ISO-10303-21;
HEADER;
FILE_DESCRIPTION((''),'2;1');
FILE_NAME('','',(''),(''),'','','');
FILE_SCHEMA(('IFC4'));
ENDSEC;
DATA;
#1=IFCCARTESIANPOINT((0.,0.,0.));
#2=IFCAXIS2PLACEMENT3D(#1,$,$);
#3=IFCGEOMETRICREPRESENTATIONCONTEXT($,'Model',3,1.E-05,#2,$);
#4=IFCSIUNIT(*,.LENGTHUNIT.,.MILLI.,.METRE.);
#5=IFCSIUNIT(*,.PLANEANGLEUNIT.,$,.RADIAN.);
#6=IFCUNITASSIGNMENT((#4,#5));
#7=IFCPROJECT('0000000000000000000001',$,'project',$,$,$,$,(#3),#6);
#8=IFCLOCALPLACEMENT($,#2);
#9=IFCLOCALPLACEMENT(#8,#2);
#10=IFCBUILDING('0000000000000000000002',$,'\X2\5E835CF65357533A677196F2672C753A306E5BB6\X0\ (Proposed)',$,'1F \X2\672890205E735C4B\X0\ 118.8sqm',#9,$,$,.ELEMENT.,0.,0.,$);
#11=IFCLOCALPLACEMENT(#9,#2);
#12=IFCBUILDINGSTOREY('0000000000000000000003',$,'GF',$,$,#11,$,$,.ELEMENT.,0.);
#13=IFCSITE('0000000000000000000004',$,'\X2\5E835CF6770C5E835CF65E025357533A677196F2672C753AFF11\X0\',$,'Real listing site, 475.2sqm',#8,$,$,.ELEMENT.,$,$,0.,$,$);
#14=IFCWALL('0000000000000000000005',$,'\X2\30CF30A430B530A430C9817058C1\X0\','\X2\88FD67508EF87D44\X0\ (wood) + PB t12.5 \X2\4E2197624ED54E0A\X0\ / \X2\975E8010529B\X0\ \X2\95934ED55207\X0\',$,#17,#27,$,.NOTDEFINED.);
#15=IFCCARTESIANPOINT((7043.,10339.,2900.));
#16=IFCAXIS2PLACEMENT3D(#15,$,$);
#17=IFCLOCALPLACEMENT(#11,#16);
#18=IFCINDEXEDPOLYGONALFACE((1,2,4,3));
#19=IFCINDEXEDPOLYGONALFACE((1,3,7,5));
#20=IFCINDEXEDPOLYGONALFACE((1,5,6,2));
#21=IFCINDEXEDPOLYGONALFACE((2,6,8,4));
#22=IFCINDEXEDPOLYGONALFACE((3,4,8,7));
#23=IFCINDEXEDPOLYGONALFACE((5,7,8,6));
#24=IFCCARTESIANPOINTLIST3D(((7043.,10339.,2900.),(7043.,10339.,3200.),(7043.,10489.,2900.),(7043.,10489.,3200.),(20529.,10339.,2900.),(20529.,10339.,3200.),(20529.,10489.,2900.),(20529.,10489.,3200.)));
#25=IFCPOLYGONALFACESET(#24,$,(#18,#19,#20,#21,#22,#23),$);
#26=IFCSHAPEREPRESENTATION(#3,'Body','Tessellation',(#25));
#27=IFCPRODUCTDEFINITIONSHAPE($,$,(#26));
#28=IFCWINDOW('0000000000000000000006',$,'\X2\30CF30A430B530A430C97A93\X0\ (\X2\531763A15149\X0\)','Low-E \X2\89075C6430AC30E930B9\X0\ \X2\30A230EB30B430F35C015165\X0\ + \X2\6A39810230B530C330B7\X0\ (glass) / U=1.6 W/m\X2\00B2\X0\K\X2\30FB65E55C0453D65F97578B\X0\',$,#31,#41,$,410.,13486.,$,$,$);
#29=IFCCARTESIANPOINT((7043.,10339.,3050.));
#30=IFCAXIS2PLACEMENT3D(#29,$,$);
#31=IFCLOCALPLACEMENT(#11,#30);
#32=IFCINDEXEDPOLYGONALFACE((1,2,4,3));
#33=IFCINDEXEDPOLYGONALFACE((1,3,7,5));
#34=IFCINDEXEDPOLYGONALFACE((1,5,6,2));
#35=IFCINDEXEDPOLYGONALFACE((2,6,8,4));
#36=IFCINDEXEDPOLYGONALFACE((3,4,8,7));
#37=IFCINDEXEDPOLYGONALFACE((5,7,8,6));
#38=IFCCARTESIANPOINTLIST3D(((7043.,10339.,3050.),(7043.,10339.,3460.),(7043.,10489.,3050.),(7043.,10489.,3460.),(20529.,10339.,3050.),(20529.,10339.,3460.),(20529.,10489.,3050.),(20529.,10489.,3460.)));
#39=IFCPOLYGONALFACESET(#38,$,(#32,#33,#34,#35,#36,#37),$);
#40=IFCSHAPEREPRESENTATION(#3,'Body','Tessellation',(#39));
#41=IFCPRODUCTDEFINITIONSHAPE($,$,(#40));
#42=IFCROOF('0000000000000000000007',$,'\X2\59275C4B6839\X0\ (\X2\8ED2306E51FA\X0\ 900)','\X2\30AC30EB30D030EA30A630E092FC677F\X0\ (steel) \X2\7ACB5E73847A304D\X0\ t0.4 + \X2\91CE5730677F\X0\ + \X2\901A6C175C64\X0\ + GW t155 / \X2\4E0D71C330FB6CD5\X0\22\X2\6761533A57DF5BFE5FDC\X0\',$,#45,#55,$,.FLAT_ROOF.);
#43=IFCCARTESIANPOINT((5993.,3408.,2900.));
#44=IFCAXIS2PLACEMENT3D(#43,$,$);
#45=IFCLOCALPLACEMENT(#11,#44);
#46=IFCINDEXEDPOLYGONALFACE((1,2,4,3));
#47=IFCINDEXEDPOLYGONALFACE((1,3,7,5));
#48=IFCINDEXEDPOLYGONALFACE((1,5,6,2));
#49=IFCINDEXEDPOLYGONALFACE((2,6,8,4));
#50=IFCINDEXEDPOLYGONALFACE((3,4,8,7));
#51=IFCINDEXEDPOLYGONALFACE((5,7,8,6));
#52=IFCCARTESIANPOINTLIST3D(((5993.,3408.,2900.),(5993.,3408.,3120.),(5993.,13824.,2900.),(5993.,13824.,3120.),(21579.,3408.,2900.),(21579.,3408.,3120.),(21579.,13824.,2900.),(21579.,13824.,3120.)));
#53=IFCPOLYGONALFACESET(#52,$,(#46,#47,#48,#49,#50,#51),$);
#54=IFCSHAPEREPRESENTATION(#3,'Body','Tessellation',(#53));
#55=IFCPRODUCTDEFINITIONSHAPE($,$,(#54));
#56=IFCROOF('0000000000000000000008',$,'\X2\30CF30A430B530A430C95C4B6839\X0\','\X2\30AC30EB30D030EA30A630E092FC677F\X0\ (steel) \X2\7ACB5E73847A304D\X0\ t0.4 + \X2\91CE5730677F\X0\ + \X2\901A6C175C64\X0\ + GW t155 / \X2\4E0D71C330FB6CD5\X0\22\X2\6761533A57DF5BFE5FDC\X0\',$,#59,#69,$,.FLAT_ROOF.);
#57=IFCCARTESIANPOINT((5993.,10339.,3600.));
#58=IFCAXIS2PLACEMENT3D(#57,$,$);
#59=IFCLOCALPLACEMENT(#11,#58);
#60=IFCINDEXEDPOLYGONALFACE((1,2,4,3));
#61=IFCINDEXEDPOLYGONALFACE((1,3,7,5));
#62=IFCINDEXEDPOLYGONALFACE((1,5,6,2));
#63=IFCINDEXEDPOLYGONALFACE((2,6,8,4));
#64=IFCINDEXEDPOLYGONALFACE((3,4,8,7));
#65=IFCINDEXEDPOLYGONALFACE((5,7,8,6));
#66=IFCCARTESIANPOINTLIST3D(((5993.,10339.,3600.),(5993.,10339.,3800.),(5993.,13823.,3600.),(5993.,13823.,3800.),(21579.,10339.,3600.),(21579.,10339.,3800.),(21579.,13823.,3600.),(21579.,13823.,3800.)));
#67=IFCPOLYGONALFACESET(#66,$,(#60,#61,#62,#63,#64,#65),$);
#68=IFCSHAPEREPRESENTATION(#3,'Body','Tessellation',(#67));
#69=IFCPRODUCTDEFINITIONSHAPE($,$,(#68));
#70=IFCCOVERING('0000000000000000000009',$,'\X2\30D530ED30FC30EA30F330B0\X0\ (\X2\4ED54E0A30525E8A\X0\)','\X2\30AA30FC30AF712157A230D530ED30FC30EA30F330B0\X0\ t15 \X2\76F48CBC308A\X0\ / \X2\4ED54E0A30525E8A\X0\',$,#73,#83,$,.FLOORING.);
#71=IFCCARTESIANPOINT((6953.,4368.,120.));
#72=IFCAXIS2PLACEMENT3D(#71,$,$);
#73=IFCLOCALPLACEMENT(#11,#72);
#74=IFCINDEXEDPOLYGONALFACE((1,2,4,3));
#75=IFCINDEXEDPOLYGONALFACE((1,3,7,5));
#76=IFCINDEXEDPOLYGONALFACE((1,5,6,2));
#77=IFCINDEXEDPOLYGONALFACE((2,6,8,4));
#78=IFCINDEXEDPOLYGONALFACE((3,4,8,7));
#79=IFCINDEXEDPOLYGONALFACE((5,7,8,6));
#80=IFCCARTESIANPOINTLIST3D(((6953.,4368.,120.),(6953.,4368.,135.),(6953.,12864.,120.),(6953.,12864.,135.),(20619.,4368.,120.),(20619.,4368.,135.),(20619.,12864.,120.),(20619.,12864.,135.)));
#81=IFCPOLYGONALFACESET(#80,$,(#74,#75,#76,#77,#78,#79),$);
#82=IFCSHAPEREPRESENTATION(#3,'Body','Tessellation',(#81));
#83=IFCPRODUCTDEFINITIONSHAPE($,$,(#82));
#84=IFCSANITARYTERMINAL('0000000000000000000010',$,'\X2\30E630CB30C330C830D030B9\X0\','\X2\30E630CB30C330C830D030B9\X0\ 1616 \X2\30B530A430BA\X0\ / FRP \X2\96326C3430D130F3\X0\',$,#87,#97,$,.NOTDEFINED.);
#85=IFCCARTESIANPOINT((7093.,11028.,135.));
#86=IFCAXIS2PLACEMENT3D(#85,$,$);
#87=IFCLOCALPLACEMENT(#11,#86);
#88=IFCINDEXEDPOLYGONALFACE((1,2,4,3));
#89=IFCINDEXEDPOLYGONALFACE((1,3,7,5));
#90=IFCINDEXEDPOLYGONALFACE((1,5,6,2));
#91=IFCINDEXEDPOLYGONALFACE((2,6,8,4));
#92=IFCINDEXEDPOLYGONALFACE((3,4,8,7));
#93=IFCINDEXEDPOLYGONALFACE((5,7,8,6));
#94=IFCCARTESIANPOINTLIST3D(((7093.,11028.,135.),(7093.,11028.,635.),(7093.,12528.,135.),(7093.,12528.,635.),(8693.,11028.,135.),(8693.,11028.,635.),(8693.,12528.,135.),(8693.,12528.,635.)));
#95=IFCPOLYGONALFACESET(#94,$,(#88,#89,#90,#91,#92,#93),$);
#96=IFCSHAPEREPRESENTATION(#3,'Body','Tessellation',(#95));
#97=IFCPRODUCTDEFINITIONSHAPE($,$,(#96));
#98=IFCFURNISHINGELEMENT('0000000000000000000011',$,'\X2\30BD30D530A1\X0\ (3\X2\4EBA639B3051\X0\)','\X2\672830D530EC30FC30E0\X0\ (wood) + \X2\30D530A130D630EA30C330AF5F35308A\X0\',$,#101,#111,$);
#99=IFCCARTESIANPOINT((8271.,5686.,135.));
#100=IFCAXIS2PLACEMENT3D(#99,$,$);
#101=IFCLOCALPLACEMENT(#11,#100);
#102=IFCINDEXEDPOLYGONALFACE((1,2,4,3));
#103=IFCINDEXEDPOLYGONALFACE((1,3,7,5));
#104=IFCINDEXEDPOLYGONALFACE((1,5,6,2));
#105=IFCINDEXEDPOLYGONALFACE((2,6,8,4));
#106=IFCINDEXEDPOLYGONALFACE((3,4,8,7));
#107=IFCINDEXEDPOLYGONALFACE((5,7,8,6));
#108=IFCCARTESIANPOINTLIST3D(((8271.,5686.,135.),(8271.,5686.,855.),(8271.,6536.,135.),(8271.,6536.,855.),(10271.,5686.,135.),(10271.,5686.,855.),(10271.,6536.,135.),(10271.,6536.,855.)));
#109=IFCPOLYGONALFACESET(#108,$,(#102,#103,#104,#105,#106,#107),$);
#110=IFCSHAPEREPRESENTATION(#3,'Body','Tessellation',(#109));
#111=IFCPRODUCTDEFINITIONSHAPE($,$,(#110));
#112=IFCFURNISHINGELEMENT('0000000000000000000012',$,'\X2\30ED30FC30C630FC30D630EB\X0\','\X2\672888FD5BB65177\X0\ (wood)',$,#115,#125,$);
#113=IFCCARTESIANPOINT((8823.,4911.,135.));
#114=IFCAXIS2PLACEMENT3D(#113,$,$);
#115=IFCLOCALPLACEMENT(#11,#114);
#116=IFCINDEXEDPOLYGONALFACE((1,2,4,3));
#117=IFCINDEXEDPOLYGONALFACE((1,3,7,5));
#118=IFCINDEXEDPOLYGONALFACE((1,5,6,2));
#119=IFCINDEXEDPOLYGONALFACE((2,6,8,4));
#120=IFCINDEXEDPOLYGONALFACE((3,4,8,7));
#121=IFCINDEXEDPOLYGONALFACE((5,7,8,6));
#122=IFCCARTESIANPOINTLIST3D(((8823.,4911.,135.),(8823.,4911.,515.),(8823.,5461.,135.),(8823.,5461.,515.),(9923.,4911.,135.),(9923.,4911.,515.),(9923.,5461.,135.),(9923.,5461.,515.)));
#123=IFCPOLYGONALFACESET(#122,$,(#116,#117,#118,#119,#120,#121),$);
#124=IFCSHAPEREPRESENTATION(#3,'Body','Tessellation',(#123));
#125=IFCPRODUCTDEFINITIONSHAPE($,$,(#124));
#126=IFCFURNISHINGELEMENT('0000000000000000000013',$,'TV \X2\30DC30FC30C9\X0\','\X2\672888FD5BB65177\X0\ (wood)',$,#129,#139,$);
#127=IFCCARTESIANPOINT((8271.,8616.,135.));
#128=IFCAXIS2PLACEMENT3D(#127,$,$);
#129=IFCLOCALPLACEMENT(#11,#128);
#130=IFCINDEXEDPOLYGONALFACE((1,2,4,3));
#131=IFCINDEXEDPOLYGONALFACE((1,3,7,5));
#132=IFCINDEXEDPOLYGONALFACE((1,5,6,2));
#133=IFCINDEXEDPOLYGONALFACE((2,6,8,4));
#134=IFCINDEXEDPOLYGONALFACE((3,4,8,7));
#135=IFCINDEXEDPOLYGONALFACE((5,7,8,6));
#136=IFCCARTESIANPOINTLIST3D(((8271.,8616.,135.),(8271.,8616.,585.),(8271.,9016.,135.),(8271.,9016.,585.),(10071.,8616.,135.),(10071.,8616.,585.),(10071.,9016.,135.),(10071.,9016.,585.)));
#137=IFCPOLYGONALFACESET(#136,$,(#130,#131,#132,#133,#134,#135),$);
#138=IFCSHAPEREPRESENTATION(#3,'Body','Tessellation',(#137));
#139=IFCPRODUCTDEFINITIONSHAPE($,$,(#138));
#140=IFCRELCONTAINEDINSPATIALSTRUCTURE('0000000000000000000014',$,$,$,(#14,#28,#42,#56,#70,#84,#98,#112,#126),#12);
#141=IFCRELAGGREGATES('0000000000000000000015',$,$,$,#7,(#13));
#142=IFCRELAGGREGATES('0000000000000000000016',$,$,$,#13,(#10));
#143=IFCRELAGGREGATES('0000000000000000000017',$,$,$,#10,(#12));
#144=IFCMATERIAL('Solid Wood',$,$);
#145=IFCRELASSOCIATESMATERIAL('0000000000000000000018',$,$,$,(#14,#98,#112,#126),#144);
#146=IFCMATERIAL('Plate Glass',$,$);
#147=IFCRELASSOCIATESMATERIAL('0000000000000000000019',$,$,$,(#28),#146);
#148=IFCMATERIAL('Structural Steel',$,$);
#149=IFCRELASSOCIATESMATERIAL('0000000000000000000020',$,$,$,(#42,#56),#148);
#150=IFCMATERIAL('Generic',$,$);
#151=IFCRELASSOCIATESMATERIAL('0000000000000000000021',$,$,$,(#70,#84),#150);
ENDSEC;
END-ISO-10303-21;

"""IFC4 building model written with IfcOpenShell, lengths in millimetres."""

from ifc_helpers import new_model, si_unit, frame, frame_2d, origin, place, context, project, spatial, rectangle, extrude, material, element, fill, save


model = new_model("IFC4")

# Units and contexts
model_context = context("Model", 3, precision=1e-05, world=origin())
ifc_project = project(units=[si_unit("LENGTHUNIT", "METRE", prefix="MILLI"), si_unit("PLANEANGLEUNIT", "RADIAN")], contexts=[model_context])

# Site, building, storey
site_placement = place(None, origin())
site = spatial("IfcSite", under=ifc_project, at=site_placement, Name="広島県広島市南区東雲本町１", ObjectType="Real listing site, 475.2sqm", CompositionType="ELEMENT", RefElevation=0.0)
building_placement = place(site_placement, origin())
building = spatial("IfcBuilding", under=site, at=building_placement, Name="広島南区東雲本町の家 (Proposed)", ObjectType="1F 木造平屋 118.8sqm", CompositionType="ELEMENT", ElevationOfRefHeight=0.0, ElevationOfTerrain=0.0)
storey_placement = place(building_placement, origin())
storey = spatial("IfcBuildingStorey", under=building, at=storey_placement, Name="GF", CompositionType="ELEMENT", Elevation=0.0)

# Shared definitions
ifc_material_1 = material(Name="Solid Wood")

# Shared definitions
ifc_material_2 = material(Name="Plate Glass")

# Wall, opening, window
wall_1_placement = place(storey_placement, frame((7043.0, 10339.0, 2900.0)))
wall_1 = element("IfcWall", 1, at=wall_1_placement, inside=storey, material=ifc_material_1, Name="ハイサイド腰壁", Description="製材軸組 (wood) + PB t12.5 両面仕上 / 非耐力 間仕切", PredefinedType="NOTDEFINED", context=model_context, shape_type="SweptSolid", body=[
    extrude(rectangle(XDim=13486.0, YDim=150.0, at=frame_2d((6743.0, 75.0))), frame((7043.0, 10339.0, 2900.0)), (0.0, 0.0, 1.0), 700.0),
])
opening_1_placement = place(storey_placement, frame((7043.0, 10339.0, 3050.0)))
opening_1 = element("IfcOpeningElement", 2, at=opening_1_placement, cuts=wall_1, PredefinedType="NOTDEFINED", context=model_context, shape_type="SweptSolid", body=[
    extrude(rectangle(XDim=13486.0, YDim=150.0, at=frame_2d((6743.0, 75.0))), frame((7043.0, 10339.0, 3050.0)), (0.0, 0.0, 1.0), 410.0),
])
window_1_placement = place(storey_placement, frame((7043.0, 10339.0, 3050.0)))
window_1 = element("IfcWindow", 3, at=window_1_placement, inside=storey, material=ifc_material_2, Name="ハイサイド窓 (北採光)", Description="Low-E 複層ガラス アルゴン封入 + 樹脂サッシ (glass) / U=1.6 W/m²K・日射取得型", OverallHeight=410.0, OverallWidth=13486.0, context=model_context, shape_type="SweptSolid", body=[
    extrude(rectangle(XDim=13486.0, YDim=150.0, at=frame_2d((6743.0, 75.0))), frame((7043.0, 10339.0, 3050.0)), (0.0, 0.0, 1.0), 410.0),
])
fill(opening_1, window_1)

# Roofs
ifc_material_3 = material(Name="Structural Steel")
roof_1_placement = place(storey_placement, frame((5993.0, 3408.0, 2900.0)))
element("IfcRoof", 4, at=roof_1_placement, inside=storey, material=ifc_material_3, Name="大屋根 (軒の出 900)", Description="ガルバリウム鋼板 (steel) 立平葺き t0.4 + 野地板 + 通気層 + GW t155 / 不燃・法22条区域対応", PredefinedType="FLAT_ROOF", context=model_context, shape_type="SweptSolid", body=[
    extrude(rectangle(XDim=15586.0, YDim=10416.0, at=frame_2d((7793.0, 5208.0))), frame((5993.0, 3408.0, 2900.0)), (0.0, 0.0, 1.0), 220.0),
])
roof_2_placement = place(storey_placement, frame((5993.0, 10339.0, 3600.0)))
element("IfcRoof", 5, at=roof_2_placement, inside=storey, material=ifc_material_3, Name="ハイサイド屋根", Description="ガルバリウム鋼板 (steel) 立平葺き t0.4 + 野地板 + 通気層 + GW t155 / 不燃・法22条区域対応", PredefinedType="FLAT_ROOF", context=model_context, shape_type="SweptSolid", body=[
    extrude(rectangle(XDim=15586.0, YDim=3484.0, at=frame_2d((7793.0, 1742.0))), frame((5993.0, 10339.0, 3600.0)), (0.0, 0.0, 1.0), 200.0),
])

# Covering
ifc_material_4 = material(Name="Generic")
covering_placement = place(storey_placement, frame((6953.0, 4368.0, 120.0)))
element("IfcCovering", 6, at=covering_placement, inside=storey, material=ifc_material_4, Name="フローリング (仕上げ床)", Description="オーク無垢フローリング t15 直貼り / 仕上げ床", PredefinedType="FLOORING", context=model_context, shape_type="SweptSolid", body=[
    extrude(rectangle(XDim=13666.0, YDim=8496.0, at=frame_2d((6833.0, 4248.0))), frame((6953.0, 4368.0, 120.0)), (0.0, 0.0, 1.0), 15.0),
])

# Sanitary terminal
sanitary_terminal_placement = place(storey_placement, frame((7093.0, 11028.0, 135.0)))
element("IfcSanitaryTerminal", 7, at=sanitary_terminal_placement, inside=storey, material=ifc_material_4, Name="ユニットバス", Description="ユニットバス 1616 サイズ / FRP 防水パン", PredefinedType="NOTDEFINED", context=model_context, shape_type="SweptSolid", body=[
    extrude(rectangle(XDim=1600.0, YDim=1500.0, at=frame_2d((800.0, 750.0))), frame((7093.0, 11028.0, 135.0)), (0.0, 0.0, 1.0), 500.0),
])

# Furnishing elements
furnishing_1_placement = place(storey_placement, frame((8271.0, 5686.0, 135.0)))
element("IfcFurnishingElement", 8, at=furnishing_1_placement, inside=storey, material=ifc_material_1, Name="ソファ (3人掛け)", Description="木フレーム (wood) + ファブリック張り", context=model_context, shape_type="SweptSolid", body=[
    extrude(rectangle(XDim=2000.0, YDim=850.0, at=frame_2d((1000.0, 425.0))), frame((8271.0, 5686.0, 135.0)), (0.0, 0.0, 1.0), 720.0),
])
furnishing_2_placement = place(storey_placement, frame((8823.0, 4911.0, 135.0)))
element("IfcFurnishingElement", 9, at=furnishing_2_placement, inside=storey, material=ifc_material_1, Name="ローテーブル", Description="木製家具 (wood)", context=model_context, shape_type="SweptSolid", body=[
    extrude(rectangle(XDim=1100.0, YDim=550.0, at=frame_2d((550.0, 275.0))), frame((8823.0, 4911.0, 135.0)), (0.0, 0.0, 1.0), 380.0),
])
furnishing_3_placement = place(storey_placement, frame((8271.0, 8616.0, 135.0)))
element("IfcFurnishingElement", 10, at=furnishing_3_placement, inside=storey, material=ifc_material_1, Name="TV ボード", Description="木製家具 (wood)", context=model_context, shape_type="SweptSolid", body=[
    extrude(rectangle(XDim=1800.0, YDim=400.0, at=frame_2d((900.0, 200.0))), frame((8271.0, 8616.0, 135.0)), (0.0, 0.0, 1.0), 450.0),
])

save(model, "model.ifc")
